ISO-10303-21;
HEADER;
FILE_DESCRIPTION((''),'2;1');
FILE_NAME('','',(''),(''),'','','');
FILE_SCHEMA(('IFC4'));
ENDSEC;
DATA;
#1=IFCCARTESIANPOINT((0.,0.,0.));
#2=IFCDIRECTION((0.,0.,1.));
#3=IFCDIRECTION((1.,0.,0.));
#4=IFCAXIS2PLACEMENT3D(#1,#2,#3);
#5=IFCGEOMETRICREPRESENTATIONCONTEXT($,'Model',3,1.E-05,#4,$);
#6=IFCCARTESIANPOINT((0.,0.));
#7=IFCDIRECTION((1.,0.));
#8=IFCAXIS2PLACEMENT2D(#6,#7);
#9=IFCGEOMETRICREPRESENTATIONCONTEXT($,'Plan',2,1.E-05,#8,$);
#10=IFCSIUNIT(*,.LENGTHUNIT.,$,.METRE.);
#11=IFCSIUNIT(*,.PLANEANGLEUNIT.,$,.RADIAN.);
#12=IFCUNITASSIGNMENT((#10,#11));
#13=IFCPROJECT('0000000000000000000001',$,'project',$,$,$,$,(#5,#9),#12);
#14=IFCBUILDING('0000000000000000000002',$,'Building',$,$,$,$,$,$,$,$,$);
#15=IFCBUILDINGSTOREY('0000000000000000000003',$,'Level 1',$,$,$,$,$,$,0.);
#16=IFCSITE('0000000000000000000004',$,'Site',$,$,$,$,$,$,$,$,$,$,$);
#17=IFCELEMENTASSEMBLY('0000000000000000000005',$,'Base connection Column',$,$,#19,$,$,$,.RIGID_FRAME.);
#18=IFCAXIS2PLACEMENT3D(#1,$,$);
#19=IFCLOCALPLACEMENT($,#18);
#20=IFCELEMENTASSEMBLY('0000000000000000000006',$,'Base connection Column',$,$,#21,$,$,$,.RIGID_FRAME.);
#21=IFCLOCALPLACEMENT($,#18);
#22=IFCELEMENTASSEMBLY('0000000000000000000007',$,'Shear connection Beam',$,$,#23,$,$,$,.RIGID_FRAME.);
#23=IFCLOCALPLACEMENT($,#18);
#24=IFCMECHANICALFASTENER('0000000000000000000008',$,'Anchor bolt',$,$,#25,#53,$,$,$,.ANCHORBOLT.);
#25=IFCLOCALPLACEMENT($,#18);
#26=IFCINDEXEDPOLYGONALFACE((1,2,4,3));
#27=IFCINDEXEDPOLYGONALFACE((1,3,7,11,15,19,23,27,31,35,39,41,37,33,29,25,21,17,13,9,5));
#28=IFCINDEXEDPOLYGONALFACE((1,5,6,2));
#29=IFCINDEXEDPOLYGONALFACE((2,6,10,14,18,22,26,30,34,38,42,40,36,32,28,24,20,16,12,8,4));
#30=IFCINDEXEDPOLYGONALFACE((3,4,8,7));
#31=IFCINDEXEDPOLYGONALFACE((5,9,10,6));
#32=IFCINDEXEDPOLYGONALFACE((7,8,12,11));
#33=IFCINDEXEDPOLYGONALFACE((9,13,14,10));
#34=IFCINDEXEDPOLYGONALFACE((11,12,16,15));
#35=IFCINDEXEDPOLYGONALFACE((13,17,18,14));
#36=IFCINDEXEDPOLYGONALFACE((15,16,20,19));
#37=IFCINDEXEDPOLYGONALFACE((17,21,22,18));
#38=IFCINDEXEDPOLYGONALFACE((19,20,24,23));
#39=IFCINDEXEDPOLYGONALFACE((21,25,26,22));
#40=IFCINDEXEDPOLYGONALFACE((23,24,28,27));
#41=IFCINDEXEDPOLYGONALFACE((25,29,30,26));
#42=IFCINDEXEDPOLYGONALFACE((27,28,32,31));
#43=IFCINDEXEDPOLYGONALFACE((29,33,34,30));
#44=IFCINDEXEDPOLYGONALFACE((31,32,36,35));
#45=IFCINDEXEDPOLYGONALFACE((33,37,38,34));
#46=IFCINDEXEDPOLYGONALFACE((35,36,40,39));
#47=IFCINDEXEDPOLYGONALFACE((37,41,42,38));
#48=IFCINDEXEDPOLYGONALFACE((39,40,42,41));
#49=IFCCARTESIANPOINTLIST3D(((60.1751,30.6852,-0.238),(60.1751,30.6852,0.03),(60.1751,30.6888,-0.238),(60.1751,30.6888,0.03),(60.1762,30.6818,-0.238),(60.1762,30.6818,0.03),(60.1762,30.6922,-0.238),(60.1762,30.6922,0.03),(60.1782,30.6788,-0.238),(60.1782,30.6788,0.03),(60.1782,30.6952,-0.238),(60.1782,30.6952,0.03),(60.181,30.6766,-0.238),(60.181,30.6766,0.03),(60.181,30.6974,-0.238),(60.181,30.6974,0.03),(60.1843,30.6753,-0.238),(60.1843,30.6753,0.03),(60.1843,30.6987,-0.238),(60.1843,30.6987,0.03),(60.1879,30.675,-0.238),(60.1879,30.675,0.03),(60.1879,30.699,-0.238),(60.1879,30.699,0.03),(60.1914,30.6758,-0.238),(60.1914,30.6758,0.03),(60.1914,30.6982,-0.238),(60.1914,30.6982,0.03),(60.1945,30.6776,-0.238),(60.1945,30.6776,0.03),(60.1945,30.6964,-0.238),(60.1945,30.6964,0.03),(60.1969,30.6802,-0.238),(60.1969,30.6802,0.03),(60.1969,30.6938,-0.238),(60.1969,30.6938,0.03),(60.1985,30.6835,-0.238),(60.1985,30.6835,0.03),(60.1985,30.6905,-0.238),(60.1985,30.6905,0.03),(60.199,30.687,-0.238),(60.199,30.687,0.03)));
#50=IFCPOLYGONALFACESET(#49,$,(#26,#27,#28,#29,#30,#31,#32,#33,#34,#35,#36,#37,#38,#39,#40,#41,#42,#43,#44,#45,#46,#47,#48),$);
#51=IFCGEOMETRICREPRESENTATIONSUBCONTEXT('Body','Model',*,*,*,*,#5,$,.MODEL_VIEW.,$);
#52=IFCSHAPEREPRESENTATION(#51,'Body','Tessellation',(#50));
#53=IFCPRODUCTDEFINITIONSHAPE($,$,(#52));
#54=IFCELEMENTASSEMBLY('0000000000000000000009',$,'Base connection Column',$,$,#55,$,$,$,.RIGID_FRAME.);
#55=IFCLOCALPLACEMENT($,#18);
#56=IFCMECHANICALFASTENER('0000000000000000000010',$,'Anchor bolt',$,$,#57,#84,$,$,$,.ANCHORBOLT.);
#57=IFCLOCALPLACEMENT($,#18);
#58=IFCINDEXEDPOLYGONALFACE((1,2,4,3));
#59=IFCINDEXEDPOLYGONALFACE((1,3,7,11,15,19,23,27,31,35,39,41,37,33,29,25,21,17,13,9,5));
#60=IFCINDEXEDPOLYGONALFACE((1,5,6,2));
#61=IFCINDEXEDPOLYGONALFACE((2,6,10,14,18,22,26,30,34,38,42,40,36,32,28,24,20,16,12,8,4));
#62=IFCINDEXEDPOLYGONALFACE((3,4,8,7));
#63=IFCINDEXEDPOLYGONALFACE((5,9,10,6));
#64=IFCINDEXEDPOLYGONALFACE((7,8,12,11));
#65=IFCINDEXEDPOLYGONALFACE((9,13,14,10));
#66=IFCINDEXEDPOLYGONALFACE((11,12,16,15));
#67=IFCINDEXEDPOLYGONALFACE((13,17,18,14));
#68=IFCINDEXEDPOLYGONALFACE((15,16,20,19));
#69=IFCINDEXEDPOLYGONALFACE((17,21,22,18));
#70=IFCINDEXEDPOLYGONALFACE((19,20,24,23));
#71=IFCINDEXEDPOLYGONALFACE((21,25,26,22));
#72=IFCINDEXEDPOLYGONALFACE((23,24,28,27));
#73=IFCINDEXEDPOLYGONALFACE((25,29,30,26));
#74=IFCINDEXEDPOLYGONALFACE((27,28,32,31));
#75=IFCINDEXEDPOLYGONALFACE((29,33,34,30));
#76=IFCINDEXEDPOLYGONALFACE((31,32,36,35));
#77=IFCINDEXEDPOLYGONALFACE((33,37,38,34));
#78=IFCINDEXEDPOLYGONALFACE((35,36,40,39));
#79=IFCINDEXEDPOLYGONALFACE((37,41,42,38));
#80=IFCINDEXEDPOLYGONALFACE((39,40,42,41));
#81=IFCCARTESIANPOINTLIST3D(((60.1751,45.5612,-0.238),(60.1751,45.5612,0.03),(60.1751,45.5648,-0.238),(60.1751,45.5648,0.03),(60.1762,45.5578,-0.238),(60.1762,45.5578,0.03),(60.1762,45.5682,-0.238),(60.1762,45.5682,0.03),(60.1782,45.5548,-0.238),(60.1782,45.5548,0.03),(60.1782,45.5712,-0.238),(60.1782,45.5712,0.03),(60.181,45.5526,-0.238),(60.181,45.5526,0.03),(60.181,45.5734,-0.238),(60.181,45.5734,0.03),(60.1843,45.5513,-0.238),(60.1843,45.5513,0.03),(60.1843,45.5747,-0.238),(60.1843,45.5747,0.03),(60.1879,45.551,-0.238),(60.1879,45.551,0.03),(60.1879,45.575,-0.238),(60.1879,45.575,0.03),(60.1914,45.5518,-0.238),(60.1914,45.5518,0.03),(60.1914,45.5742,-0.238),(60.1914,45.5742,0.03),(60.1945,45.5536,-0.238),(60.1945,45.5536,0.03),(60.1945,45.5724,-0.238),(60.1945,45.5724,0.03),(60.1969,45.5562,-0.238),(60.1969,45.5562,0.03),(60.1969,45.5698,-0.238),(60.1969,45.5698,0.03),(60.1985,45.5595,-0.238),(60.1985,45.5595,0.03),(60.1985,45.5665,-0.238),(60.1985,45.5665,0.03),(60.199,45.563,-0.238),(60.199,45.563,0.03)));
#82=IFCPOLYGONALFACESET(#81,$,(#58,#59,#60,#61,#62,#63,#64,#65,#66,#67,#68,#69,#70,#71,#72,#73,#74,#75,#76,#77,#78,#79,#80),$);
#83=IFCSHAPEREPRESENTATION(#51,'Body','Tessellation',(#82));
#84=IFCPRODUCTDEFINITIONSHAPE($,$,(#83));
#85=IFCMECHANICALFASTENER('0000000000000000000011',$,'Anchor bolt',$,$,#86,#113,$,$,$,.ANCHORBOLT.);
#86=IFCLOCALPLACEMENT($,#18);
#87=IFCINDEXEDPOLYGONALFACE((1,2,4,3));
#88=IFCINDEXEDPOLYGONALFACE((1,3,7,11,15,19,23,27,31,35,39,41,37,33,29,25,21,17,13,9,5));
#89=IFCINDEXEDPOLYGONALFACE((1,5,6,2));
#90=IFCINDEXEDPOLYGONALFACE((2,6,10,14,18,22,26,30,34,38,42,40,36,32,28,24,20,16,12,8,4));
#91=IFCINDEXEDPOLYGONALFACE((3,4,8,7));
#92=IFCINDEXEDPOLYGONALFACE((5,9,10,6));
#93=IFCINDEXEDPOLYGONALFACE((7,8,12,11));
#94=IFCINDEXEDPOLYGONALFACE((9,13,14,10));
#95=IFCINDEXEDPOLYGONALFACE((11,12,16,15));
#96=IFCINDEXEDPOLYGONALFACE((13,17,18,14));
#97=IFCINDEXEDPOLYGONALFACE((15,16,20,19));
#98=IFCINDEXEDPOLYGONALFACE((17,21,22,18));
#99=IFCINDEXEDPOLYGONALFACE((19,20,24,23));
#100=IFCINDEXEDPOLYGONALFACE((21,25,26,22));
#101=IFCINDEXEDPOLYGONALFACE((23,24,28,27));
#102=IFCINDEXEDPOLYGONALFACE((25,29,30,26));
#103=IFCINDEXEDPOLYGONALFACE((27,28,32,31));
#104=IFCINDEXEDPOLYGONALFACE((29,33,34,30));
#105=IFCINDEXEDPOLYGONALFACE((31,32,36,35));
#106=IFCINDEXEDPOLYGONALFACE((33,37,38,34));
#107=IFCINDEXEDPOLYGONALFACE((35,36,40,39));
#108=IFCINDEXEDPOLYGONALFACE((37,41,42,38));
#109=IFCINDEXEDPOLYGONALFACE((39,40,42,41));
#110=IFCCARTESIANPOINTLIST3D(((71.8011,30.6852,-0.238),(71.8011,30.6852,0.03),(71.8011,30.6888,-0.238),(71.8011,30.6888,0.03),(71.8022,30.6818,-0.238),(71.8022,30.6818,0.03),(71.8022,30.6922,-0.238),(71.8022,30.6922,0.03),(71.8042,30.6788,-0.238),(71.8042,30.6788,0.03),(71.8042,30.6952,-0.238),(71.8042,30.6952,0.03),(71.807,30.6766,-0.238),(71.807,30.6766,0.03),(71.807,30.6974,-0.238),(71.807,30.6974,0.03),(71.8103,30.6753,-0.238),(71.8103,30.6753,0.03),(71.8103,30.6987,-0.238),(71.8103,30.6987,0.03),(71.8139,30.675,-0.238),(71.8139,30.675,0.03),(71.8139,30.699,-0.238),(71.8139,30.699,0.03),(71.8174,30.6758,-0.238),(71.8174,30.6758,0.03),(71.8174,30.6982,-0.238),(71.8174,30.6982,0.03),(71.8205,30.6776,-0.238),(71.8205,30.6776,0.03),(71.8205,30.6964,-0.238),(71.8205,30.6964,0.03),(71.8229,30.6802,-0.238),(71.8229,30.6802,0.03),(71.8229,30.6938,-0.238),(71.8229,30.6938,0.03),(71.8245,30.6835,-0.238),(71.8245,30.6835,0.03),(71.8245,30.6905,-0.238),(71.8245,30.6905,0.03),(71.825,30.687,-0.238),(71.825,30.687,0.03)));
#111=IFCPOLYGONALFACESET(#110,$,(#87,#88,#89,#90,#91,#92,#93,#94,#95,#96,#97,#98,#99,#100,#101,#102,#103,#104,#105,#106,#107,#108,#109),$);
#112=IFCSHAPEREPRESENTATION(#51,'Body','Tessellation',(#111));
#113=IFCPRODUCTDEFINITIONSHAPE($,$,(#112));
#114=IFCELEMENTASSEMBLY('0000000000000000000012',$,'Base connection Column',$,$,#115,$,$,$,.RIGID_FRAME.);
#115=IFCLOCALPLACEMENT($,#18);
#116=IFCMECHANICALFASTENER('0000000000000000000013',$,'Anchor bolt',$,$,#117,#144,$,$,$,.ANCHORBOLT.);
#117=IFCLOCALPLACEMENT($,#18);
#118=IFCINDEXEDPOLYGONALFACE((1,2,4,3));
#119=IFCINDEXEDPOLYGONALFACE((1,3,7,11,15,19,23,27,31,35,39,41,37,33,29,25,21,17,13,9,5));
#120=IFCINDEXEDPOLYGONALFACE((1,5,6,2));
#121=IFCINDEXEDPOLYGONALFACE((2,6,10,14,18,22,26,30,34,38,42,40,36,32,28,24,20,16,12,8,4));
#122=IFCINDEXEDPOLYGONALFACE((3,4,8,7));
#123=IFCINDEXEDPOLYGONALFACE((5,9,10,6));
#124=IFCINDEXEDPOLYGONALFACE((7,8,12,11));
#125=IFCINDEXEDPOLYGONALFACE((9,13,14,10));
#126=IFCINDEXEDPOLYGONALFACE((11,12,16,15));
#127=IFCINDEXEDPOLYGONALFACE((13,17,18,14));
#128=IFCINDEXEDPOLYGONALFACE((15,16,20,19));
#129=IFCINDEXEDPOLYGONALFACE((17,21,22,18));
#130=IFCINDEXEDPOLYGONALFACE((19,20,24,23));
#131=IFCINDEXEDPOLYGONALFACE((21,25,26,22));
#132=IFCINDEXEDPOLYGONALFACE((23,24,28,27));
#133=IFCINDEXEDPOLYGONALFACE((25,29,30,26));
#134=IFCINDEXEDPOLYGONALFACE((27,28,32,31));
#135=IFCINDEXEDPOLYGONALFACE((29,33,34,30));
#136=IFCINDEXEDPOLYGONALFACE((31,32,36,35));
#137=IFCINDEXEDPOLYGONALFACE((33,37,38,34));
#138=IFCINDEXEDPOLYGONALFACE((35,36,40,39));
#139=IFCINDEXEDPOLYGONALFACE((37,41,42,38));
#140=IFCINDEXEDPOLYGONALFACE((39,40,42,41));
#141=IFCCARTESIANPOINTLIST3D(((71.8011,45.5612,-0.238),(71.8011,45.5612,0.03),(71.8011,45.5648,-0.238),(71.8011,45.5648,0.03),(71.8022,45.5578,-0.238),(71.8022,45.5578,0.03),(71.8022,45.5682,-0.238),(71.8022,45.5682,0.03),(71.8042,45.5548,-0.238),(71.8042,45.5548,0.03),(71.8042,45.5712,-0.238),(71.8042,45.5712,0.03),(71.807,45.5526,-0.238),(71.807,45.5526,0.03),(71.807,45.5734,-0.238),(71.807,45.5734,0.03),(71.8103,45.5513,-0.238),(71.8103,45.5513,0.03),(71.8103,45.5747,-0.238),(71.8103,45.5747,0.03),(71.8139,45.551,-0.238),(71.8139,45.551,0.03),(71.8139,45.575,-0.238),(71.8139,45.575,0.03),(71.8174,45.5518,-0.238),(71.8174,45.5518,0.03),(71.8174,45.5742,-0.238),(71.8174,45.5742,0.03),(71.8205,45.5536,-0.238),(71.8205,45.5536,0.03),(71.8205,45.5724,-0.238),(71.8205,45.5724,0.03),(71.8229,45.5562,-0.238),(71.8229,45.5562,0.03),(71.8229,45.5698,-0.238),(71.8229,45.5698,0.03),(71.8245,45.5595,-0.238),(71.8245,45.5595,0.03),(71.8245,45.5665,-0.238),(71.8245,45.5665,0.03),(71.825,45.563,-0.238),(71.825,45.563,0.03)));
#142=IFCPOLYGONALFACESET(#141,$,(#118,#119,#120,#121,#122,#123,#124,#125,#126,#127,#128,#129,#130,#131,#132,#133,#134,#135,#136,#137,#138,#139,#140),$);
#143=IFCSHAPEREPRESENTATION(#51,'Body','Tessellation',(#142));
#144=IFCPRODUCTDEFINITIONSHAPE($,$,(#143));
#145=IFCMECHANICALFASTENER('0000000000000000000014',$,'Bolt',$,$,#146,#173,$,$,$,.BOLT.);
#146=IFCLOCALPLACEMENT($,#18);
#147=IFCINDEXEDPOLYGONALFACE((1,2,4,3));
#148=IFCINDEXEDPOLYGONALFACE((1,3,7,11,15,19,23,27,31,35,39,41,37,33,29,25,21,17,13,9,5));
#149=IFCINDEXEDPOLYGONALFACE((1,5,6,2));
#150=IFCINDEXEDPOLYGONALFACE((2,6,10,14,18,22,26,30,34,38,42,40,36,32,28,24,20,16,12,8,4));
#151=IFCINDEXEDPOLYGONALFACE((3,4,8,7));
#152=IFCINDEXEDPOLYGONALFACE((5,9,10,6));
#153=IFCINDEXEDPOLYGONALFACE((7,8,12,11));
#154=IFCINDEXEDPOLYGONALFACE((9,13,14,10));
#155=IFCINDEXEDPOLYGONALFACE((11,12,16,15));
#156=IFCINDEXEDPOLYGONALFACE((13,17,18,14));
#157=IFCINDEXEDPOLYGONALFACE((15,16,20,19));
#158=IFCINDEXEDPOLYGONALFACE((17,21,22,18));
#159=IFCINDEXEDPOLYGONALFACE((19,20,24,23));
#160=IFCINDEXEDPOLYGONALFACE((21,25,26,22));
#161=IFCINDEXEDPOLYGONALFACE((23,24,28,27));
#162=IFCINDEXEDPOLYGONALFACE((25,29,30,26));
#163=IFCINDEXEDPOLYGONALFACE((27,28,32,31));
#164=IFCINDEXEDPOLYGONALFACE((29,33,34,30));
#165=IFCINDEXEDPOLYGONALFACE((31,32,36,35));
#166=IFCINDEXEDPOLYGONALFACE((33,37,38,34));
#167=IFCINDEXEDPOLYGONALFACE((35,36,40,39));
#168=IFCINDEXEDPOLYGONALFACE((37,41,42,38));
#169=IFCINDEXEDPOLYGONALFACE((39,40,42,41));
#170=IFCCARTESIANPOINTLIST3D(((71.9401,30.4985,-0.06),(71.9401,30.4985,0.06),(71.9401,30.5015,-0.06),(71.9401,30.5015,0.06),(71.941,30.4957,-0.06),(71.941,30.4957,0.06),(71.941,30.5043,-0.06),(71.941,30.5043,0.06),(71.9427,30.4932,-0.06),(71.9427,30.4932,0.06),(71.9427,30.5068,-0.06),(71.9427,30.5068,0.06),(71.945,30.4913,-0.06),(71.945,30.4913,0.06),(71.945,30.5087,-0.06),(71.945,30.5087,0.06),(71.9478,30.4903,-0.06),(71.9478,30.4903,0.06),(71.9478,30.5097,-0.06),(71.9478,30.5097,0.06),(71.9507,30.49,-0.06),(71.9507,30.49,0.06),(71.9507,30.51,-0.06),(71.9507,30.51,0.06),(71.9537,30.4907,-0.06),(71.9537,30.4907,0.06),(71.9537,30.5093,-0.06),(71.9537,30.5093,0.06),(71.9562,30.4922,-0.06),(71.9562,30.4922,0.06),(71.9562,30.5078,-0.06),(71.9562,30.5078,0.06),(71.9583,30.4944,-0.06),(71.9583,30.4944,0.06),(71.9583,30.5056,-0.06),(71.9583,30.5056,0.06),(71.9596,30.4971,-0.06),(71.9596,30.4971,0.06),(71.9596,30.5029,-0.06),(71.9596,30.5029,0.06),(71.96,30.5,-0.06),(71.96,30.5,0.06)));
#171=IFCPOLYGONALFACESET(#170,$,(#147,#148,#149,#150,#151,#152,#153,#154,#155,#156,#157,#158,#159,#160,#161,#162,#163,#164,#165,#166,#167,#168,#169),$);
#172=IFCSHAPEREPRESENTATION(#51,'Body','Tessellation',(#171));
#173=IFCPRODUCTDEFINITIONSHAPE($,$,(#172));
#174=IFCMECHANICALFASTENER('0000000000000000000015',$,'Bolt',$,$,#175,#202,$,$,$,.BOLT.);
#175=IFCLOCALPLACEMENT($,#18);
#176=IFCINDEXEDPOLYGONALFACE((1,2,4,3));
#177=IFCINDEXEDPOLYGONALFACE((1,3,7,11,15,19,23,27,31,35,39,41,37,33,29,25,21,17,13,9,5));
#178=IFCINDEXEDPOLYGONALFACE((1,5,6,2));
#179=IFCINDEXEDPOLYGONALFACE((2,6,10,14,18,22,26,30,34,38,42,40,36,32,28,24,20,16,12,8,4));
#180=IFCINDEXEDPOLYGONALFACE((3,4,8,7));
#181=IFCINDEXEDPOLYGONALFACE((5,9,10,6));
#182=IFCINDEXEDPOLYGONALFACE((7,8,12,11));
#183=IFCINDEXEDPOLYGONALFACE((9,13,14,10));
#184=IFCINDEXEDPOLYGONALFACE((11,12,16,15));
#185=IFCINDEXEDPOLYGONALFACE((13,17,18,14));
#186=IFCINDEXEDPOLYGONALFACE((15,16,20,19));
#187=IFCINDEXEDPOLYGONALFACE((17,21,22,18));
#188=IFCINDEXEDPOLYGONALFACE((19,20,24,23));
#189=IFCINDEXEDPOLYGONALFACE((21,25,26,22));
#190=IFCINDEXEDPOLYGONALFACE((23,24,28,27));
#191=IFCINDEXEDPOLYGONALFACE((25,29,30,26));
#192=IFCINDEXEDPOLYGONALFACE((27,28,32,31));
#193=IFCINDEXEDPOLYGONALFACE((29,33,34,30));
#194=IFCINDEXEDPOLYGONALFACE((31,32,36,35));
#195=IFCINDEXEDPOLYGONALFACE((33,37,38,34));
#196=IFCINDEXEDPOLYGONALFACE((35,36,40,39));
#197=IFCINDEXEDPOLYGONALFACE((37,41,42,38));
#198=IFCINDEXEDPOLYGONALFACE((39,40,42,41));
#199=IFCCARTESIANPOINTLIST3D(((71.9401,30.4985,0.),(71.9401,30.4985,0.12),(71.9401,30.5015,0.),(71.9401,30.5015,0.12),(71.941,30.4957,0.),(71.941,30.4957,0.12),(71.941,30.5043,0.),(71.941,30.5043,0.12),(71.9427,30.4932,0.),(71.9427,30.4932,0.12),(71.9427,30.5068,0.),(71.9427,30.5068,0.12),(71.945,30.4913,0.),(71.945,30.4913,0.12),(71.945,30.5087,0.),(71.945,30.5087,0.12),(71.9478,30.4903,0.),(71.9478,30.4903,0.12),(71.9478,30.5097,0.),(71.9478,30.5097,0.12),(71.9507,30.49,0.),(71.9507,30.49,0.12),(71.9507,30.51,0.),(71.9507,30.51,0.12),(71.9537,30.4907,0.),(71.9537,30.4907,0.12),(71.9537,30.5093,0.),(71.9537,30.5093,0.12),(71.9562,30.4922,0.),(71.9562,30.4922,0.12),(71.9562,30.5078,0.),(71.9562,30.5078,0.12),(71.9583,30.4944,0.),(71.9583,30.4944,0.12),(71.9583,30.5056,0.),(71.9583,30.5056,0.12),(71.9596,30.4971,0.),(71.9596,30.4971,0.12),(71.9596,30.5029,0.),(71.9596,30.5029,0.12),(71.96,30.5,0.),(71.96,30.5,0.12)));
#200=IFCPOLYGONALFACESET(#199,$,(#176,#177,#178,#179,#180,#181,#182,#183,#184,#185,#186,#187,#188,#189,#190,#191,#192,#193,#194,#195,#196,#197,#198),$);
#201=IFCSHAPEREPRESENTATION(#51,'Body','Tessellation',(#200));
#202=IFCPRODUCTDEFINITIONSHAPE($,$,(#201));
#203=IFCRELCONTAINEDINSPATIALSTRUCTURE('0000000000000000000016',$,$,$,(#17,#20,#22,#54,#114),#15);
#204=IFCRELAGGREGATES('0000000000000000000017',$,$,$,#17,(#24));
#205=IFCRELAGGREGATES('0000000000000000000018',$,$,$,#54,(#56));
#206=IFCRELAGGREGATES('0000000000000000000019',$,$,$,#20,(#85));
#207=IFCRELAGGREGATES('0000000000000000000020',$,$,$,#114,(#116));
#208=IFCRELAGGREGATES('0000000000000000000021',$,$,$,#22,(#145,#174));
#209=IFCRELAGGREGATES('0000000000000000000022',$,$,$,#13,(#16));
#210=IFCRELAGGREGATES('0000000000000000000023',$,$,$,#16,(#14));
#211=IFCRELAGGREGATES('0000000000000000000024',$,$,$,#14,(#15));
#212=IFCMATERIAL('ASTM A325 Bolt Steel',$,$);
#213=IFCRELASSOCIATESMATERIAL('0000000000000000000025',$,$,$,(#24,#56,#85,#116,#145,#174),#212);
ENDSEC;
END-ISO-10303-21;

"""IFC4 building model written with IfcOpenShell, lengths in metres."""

from ifc_helpers import new_model, si_unit, frame, origin_with_axes, origin_2d, origin_2d_with_axis, place, context, subcontext, project, spatial, circle, extrude, material, element, aggregate, save


model = new_model("IFC4")

# Units and contexts
model_context = context("Model", 3, precision=1e-05, world=origin_with_axes())
plan_context = context("Plan", 2, precision=1e-05, world=origin_2d_with_axis())
body_context = subcontext(model_context, "Body", "Model", "MODEL_VIEW")
ifc_project = project(units=[si_unit("LENGTHUNIT", "METRE"), si_unit("PLANEANGLEUNIT", "RADIAN")], contexts=[model_context, plan_context])

# Site, building, storey
site = spatial("IfcSite", under=ifc_project, Name="Site")
building = spatial("IfcBuilding", under=site, Name="Building")
storey = spatial("IfcBuildingStorey", under=building, Name="Level 1", Elevation=0.0)

# Element assemblies
assembly_1 = element("IfcElementAssembly", 1, inside=storey, Name="Base connection Column", PredefinedType="RIGID_FRAME")
assembly_2 = element("IfcElementAssembly", 2, inside=storey, Name="Base connection Column", PredefinedType="RIGID_FRAME")

# Element assembly
assembly_3 = element("IfcElementAssembly", 3, inside=storey, Name="Shear connection Beam", PredefinedType="RIGID_FRAME")

# Mechanical fastener
ifc_material_1 = material(Name="ASTM A325 Bolt Steel")
mechanical_fastener_1_placement = place(None, frame((60.187, 30.687, -0.238), z_axis=(0.0, 0.0, 1.0), x_axis=(1.0, 0.0, 0.0)))
mechanical_fastener_1 = element("IfcMechanicalFastener", 4, at=mechanical_fastener_1_placement, material=ifc_material_1, Name="Anchor bolt", PredefinedType="ANCHORBOLT", context=body_context, shape_type="SweptSolid", body=[
    extrude(circle(Radius=0.012, at=origin_2d()), origin_with_axes(), (0.0, 0.0, 1.0), 0.268),
])
aggregate(assembly_1, [mechanical_fastener_1])

# Element assembly, mechanical fastener
assembly_4 = element("IfcElementAssembly", 5, inside=storey, Name="Base connection Column", PredefinedType="RIGID_FRAME")
mechanical_fastener_2_placement = place(None, frame((60.187, 45.563, -0.238), z_axis=(0.0, 0.0, 1.0), x_axis=(1.0, 0.0, 0.0)))
mechanical_fastener_2 = element("IfcMechanicalFastener", 6, at=mechanical_fastener_2_placement, material=ifc_material_1, Name="Anchor bolt", PredefinedType="ANCHORBOLT", context=body_context, shape_type="SweptSolid", body=[
    extrude(circle(Radius=0.012, at=origin_2d()), origin_with_axes(), (0.0, 0.0, 1.0), 0.268),
])
aggregate(assembly_4, [mechanical_fastener_2])

# Mechanical fastener
mechanical_fastener_3_placement = place(None, frame((71.813, 30.687, -0.238), z_axis=(0.0, 0.0, 1.0), x_axis=(1.0, 0.0, 0.0)))
mechanical_fastener_3 = element("IfcMechanicalFastener", 7, at=mechanical_fastener_3_placement, material=ifc_material_1, Name="Anchor bolt", PredefinedType="ANCHORBOLT", context=body_context, shape_type="SweptSolid", body=[
    extrude(circle(Radius=0.012, at=origin_2d()), origin_with_axes(), (0.0, 0.0, 1.0), 0.268),
])
aggregate(assembly_2, [mechanical_fastener_3])

# Element assembly, mechanical fastener
assembly_5 = element("IfcElementAssembly", 8, inside=storey, Name="Base connection Column", PredefinedType="RIGID_FRAME")
mechanical_fastener_4_placement = place(None, frame((71.813, 45.563, -0.238), z_axis=(0.0, 0.0, 1.0), x_axis=(1.0, 0.0, 0.0)))
mechanical_fastener_4 = element("IfcMechanicalFastener", 9, at=mechanical_fastener_4_placement, material=ifc_material_1, Name="Anchor bolt", PredefinedType="ANCHORBOLT", context=body_context, shape_type="SweptSolid", body=[
    extrude(circle(Radius=0.012, at=origin_2d()), origin_with_axes(), (0.0, 0.0, 1.0), 0.268),
])
aggregate(assembly_5, [mechanical_fastener_4])

# Mechanical fasteners
mechanical_fastener_5_placement = place(None, frame((71.95, 30.5, -0.06), z_axis=(0.0, 0.0, 1.0), x_axis=(1.0, 0.0, 0.0)))
mechanical_fastener_5 = element("IfcMechanicalFastener", 10, at=mechanical_fastener_5_placement, material=ifc_material_1, Name="Bolt", PredefinedType="BOLT", context=body_context, shape_type="SweptSolid", body=[
    extrude(circle(Radius=0.01, at=origin_2d()), origin_with_axes(), (0.0, 0.0, 1.0), 0.12),
])
mechanical_fastener_6_placement = place(None, frame((71.95, 30.5, 0.0), z_axis=(0.0, 0.0, 1.0), x_axis=(1.0, 0.0, 0.0)))
mechanical_fastener_6 = element("IfcMechanicalFastener", 11, at=mechanical_fastener_6_placement, material=ifc_material_1, Name="Bolt", PredefinedType="BOLT", context=body_context, shape_type="SweptSolid", body=[
    extrude(circle(Radius=0.01, at=origin_2d()), origin_with_axes(), (0.0, 0.0, 1.0), 0.12),
])
aggregate(assembly_3, [mechanical_fastener_5, mechanical_fastener_6])

save(model, "model.ifc")
